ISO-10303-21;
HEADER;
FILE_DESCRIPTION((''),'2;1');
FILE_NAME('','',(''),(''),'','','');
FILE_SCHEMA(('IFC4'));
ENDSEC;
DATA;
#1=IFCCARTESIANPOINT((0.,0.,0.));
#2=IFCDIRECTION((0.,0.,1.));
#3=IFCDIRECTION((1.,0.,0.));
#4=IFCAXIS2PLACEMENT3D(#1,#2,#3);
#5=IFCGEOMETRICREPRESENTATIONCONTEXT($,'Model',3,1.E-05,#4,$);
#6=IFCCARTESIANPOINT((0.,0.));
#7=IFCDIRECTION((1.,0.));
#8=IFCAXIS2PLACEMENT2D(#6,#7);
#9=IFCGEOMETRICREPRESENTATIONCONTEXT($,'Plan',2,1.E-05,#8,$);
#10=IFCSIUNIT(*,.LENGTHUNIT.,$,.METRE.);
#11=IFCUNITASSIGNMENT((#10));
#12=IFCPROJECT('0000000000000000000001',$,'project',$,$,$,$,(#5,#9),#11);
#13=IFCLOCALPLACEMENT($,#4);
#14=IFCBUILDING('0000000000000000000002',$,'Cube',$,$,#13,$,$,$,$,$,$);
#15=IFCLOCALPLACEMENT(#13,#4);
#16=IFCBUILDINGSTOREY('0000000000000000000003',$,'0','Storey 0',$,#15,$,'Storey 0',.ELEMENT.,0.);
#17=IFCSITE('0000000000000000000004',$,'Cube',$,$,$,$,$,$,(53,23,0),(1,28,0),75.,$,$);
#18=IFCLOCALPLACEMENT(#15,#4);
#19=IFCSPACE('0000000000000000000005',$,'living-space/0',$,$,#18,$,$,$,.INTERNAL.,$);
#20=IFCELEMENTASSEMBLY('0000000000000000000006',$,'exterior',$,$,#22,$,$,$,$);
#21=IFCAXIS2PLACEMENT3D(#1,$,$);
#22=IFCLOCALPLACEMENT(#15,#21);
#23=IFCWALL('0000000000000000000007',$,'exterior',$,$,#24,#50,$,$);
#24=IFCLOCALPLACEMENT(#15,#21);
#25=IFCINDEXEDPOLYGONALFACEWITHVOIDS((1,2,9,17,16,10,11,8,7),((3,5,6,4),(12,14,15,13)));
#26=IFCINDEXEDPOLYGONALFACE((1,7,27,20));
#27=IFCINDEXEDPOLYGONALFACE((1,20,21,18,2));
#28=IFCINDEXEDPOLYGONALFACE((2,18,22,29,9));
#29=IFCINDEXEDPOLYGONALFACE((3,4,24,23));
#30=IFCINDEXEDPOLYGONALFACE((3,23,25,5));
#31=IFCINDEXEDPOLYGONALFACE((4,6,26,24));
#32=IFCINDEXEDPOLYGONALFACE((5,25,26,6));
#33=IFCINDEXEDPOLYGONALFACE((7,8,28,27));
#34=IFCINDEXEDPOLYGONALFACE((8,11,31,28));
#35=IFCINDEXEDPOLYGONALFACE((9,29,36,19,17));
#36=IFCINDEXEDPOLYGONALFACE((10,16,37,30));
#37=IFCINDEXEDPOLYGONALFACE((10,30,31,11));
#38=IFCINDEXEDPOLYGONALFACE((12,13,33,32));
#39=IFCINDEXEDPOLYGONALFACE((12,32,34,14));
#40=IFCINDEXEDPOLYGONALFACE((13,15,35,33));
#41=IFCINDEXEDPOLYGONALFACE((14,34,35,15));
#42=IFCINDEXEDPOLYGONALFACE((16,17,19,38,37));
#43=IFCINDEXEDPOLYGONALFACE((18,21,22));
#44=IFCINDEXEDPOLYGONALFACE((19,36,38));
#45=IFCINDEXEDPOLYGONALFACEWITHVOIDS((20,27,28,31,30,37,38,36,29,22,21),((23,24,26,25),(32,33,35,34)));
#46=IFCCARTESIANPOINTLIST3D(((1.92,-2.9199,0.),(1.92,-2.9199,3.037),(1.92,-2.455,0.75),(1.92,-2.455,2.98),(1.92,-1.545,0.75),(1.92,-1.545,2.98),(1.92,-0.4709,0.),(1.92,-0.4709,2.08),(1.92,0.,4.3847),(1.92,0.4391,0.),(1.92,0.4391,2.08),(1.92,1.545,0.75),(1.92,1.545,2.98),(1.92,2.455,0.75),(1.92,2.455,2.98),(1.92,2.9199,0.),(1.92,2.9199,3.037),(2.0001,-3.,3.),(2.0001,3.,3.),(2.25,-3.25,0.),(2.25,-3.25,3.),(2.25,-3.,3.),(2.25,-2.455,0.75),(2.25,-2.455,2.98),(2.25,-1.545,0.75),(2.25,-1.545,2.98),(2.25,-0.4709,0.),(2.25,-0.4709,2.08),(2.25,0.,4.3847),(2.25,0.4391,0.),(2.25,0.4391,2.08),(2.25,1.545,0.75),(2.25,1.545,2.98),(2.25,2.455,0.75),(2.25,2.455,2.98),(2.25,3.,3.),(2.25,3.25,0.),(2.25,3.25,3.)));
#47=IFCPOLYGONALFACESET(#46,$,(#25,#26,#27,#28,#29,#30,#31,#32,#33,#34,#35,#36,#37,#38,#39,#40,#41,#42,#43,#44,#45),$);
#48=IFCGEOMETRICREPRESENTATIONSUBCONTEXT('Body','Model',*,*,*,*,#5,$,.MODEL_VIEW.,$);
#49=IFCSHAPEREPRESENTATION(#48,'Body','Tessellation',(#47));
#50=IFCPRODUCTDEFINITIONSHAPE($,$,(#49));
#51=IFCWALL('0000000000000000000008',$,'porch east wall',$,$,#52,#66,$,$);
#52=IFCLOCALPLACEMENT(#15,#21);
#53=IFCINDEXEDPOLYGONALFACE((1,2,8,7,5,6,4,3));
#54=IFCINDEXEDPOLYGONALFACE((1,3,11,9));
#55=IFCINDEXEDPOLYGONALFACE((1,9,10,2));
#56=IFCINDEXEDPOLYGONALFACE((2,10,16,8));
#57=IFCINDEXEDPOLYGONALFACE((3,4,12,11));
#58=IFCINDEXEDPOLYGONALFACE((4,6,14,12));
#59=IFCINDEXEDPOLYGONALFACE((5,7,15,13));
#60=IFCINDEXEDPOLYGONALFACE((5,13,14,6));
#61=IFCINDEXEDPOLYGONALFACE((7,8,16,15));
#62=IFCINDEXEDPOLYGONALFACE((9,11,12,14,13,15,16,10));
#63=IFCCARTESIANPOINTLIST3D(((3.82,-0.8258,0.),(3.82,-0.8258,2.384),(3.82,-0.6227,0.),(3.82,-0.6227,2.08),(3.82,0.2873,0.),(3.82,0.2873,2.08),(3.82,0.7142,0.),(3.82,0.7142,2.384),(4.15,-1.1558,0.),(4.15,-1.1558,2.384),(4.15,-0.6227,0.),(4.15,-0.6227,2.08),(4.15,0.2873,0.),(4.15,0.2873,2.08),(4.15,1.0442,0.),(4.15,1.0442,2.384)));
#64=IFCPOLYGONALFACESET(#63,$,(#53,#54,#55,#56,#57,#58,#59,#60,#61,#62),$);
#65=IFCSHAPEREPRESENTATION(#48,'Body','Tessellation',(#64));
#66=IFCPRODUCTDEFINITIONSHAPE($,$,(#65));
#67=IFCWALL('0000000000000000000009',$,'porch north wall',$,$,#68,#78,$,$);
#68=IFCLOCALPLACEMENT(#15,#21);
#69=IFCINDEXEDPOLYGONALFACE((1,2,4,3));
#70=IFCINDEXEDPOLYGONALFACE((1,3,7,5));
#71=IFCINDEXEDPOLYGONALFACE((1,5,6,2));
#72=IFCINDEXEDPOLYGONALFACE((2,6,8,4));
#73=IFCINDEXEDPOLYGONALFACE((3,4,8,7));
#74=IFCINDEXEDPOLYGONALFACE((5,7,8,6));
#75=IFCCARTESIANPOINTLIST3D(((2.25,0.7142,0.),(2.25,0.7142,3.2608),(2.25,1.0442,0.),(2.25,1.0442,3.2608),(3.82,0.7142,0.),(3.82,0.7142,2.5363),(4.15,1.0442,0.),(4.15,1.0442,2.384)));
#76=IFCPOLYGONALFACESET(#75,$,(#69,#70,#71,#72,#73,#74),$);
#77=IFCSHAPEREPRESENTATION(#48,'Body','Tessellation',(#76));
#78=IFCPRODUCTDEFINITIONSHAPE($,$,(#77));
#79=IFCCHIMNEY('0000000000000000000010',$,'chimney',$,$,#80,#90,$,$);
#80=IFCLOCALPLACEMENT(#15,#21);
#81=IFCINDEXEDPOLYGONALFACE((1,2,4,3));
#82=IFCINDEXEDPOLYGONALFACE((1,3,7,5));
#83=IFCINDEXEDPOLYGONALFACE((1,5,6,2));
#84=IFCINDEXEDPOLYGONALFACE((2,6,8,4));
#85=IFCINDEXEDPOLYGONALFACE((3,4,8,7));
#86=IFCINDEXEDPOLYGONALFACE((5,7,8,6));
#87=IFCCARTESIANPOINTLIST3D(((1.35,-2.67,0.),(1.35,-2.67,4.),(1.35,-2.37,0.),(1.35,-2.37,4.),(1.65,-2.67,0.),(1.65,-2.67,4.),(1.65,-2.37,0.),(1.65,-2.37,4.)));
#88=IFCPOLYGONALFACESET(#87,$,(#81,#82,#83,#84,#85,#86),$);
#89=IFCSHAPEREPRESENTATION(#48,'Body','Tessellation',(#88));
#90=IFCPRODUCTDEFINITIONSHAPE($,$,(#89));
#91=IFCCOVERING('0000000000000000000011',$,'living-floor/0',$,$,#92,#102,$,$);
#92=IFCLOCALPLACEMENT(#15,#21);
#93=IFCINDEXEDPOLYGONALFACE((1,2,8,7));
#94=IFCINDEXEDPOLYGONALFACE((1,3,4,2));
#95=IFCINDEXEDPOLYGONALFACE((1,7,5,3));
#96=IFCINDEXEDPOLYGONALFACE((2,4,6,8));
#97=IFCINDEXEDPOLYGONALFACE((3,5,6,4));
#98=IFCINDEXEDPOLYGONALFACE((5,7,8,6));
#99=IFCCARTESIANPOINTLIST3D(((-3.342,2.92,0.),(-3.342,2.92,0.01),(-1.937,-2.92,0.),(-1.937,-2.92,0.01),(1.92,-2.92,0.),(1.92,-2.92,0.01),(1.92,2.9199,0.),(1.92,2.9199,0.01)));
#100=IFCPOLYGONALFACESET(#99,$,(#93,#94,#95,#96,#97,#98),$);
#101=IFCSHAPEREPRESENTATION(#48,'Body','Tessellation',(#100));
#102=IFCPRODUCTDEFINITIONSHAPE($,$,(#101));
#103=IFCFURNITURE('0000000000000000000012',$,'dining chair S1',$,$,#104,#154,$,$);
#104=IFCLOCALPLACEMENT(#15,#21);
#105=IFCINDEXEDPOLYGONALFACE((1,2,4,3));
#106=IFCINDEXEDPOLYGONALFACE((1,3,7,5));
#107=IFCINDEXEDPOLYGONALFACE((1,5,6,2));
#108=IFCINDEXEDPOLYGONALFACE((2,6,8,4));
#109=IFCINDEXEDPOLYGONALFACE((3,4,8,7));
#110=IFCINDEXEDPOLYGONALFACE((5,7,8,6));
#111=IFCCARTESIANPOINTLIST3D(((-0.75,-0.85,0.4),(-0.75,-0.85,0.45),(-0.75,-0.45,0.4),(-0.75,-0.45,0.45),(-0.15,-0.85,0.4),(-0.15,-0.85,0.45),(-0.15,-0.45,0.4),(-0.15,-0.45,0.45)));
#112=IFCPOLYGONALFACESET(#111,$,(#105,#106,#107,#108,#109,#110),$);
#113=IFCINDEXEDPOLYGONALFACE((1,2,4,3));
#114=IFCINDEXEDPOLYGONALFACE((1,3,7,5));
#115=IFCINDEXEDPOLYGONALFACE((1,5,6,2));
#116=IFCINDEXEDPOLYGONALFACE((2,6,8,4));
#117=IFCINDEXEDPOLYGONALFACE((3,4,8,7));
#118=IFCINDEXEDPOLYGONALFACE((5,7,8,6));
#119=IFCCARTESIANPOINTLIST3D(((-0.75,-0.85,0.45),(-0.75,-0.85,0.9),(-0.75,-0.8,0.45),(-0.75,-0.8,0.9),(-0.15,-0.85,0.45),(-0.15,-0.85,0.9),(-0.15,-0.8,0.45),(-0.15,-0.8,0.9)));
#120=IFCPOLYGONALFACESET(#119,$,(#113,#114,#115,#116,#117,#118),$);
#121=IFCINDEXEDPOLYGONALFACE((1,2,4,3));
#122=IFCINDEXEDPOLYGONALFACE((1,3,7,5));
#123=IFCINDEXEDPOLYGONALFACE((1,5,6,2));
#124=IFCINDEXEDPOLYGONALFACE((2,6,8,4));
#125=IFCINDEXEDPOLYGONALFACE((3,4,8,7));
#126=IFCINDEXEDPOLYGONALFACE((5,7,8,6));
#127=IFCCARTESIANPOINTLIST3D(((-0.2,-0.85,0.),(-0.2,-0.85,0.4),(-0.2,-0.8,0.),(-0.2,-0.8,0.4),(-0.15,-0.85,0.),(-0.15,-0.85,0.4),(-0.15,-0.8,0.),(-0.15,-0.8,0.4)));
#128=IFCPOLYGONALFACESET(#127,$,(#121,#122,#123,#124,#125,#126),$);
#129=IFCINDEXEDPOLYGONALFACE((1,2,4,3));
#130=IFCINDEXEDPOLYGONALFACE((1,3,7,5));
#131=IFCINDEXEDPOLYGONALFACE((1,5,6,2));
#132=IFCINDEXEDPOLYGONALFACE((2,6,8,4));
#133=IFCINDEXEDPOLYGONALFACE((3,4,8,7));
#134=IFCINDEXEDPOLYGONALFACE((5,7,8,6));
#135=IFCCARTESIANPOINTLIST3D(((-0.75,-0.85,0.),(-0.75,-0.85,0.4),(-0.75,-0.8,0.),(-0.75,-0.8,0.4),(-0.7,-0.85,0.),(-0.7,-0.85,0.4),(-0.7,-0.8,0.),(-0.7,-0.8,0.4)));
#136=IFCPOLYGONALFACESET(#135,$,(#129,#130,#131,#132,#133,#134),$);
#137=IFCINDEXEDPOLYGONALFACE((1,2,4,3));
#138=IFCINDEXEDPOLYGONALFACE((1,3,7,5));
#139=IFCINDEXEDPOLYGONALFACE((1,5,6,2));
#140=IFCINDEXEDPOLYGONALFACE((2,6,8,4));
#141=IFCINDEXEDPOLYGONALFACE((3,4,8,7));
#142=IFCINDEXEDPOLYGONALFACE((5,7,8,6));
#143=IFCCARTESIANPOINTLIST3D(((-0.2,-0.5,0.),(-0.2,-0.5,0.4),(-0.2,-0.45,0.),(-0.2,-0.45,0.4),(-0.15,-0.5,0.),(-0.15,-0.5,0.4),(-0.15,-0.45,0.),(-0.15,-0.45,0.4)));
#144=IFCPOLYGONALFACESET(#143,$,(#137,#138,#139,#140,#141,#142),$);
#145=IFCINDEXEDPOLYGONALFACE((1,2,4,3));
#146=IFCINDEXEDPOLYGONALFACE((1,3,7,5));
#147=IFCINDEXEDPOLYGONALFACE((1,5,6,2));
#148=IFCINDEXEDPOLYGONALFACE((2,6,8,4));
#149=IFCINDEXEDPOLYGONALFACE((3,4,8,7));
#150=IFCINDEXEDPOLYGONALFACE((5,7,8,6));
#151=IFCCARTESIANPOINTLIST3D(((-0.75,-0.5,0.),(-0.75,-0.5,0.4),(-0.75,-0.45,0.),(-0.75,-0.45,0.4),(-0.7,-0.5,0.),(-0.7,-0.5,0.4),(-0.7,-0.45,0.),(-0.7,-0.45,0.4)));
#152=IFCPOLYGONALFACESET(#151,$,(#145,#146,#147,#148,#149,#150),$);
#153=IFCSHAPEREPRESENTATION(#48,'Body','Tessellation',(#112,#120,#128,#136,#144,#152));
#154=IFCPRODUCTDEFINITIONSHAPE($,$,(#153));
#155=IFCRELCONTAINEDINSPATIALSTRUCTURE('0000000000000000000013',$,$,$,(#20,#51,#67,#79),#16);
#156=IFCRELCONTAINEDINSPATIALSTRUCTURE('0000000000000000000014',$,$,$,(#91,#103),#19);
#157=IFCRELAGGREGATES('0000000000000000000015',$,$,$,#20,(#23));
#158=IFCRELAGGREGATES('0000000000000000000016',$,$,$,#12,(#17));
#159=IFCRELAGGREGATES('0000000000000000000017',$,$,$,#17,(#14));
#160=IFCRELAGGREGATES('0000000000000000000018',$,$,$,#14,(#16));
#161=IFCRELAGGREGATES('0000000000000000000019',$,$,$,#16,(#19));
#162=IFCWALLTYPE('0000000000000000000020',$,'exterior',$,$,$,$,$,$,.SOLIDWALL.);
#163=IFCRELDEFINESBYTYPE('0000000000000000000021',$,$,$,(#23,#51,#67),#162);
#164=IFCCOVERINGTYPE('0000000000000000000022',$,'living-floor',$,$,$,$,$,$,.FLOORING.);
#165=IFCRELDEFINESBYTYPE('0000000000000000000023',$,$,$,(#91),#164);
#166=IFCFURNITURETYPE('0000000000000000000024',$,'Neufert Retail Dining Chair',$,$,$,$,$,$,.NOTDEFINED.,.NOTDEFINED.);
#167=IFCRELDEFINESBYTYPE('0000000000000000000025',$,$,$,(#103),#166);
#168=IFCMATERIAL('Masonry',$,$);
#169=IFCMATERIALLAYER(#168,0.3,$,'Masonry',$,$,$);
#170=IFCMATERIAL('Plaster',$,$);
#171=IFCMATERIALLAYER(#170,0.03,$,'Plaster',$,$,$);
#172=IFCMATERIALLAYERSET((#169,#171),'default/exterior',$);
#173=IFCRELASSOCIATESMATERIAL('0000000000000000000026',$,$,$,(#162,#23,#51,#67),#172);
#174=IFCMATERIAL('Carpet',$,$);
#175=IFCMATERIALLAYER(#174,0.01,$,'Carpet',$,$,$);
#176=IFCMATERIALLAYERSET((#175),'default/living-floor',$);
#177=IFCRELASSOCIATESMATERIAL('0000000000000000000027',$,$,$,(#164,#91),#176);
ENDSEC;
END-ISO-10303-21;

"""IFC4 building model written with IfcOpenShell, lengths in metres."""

from ifc_helpers import new_model, entity, si_unit, frame, origin, origin_with_axes, origin_2d_with_axis, place, context, subcontext, project, spatial, polyline, line, indexed_curve, outline, extrude, clip, halfspace, bounded_halfspace, shape, source, transform, mapped, material, layer, layer_set, layer_usage, type_object, type_shapes, element, aggregate, save


model = new_model("IFC4")

# Units and contexts
model_context = context("Model", 3, precision=1e-05, world=origin_with_axes())
plan_context = context("Plan", 2, precision=1e-05, world=origin_2d_with_axis())
body_context_1 = subcontext(model_context, "Body", "Model", "MODEL_VIEW")
body_context_2 = subcontext(plan_context, "Body", "Plan", "PLAN_VIEW")
ifc_project = project(units=[si_unit("LENGTHUNIT", "METRE")], contexts=[model_context, plan_context])

# Site, building, storey
site = spatial("IfcSite", under=ifc_project, Name="Cube", RefLatitude=(53, 23, 0), RefLongitude=(1, 28, 0), RefElevation=75.0)
building_placement = place(None, origin_with_axes())
building = spatial("IfcBuilding", under=site, at=building_placement, Name="Cube")
storey_placement = place(building_placement, origin_with_axes())
storey = spatial("IfcBuildingStorey", under=building, at=storey_placement, Name="0", Description="Storey 0", LongName="Storey 0", CompositionType="ELEMENT", Elevation=0.0)

# Element assembly, wall, openings
ifc_material_1 = material(Name="Masonry")
ifc_layer_1 = layer(ifc_material_1, 0.3, Name="Masonry")
ifc_material_2 = material(Name="Plaster")
ifc_layer_2 = layer(ifc_material_2, 0.03, Name="Plaster")
ifc_layer_set_1 = layer_set([ifc_layer_1, ifc_layer_2], Name="default/exterior")
wall_type = type_object("IfcWallType", Name="exterior", PredefinedType="SOLIDWALL", material=ifc_layer_set_1)
assembly_1_placement = place(storey_placement, frame((2.0, -3.0, 0.0), z_axis=(0.0, 0.0, 1.0), x_axis=(0.0, 1.0, 0.0)))
assembly_1 = element("IfcElementAssembly", 1, at=assembly_1_placement, inside=storey, Name="exterior")
ifc_layer_usage_1 = layer_usage(ifc_layer_set_1, "AXIS2", "POSITIVE", -0.25)
wall_1_placement = place(assembly_1_placement, origin_with_axes())
wall_1 = element("IfcWall", 2, at=wall_1_placement, type_object=wall_type, material=ifc_layer_usage_1, Name="exterior", context=body_context_1, shape_type="Clipping", body=[
    clip(clip(clip(clip(extrude(outline(polyline([(0.0801, 0.08), (-0.25, -0.25), (6.25, -0.25), (5.9199, 0.08), (0.0801, 0.08)])), origin(), (0.0, 0.0, 1.0), 4.385), bounded_halfspace(frame((6.0, 0.0, 3.0), z_axis=(0.419069, 0.0, 0.907954), x_axis=(0.0, -1.0, 0.0)), False, origin(), polyline([(6.0, -1.0), (3.0, -1.0), (3.0, 1.0), (6.0, 1.0), (6.0, -1.0)]))), bounded_halfspace(frame((6.0, 0.0, 3.0), z_axis=(0.0, 0.0, 1.0), x_axis=(0.0, 1.0, 0.0)), False, origin(), polyline([(6.0, 1.0), (7.0, 1.0), (7.0, -1.0), (6.0, -1.0), (6.0, 1.0)]))), bounded_halfspace(frame((3.0, 0.0, 4.3847), z_axis=(-0.419069, 0.0, 0.907954), x_axis=(0.0, -1.0, 0.0)), False, origin(), polyline([(3.0, -1.0), (0.0, -1.0), (0.0, 1.0), (3.0, 1.0), (3.0, -1.0)]))), bounded_halfspace(frame((0.0, 0.0, 3.0), z_axis=(0.0, 0.0, 1.0), x_axis=(0.0, -1.0, 0.0)), False, origin(), polyline([(0.0, -1.0), (-1.0, -1.0), (-1.0, 1.0), (0.0, 1.0), (0.0, -1.0)]))),
])
opening_1_placement = place(wall_1_placement, frame((0.545, -0.25, 0.75), z_axis=(0.0, 0.0, 1.0), x_axis=(1.0, 0.0, 0.0)))
element("IfcOpeningElement", 3, at=opening_1_placement, cuts=wall_1, PredefinedType="OPENING", context=body_context_1, shape_type="SweptSolid", body=[
    extrude(outline(polyline([(0.0, -0.02), (0.91, -0.02), (0.91, 0.35), (0.0, 0.35), (0.0, -0.02)])), origin(), (0.0, 0.0, 1.0), 2.23),
])
opening_2_placement = place(wall_1_placement, frame((4.545, -0.25, 0.75), z_axis=(0.0, 0.0, 1.0), x_axis=(1.0, 0.0, 0.0)))
element("IfcOpeningElement", 4, at=opening_2_placement, cuts=wall_1, PredefinedType="OPENING", context=body_context_1, shape_type="SweptSolid", body=[
    extrude(outline(polyline([(0.0, -0.02), (0.91, -0.02), (0.91, 0.35), (0.0, 0.35), (0.0, -0.02)])), origin(), (0.0, 0.0, 1.0), 2.23),
])
shared_shape_1 = source(origin_with_axes(), body_context_1, "Body", "SweptSolid", [
    extrude(outline(indexed_curve([(0.0, 0.0), (0.91, 0.0), (0.91, 2.08), (0.0, 2.08)], segments=[line(1, 2, 3, 4, 1)])), frame((0.0, -0.6, 0.0), z_axis=(0.0, -1.0, 0.0), x_axis=(1.0, 0.0, 0.0)), (0.0, 0.0, -1.0), 1.2),
])
opening_3_placement = place(wall_1_placement, frame((2.5291, -0.25, 0.0), z_axis=(0.0, 0.0, 1.0), x_axis=(1.0, 0.0, 0.0)))
element("IfcOpeningElement", 5, at=opening_3_placement, cuts=wall_1, PredefinedType="OPENING", context=body_context_1, shape_type="MappedRepresentation", body=[
    mapped(shared_shape_1, transform((0.0, 0.0, 0.0), x_axis=(1.0, 0.0, 0.0), y_axis=(0.0, 1.0, 0.0), z_axis=(0.0, 0.0, 1.0), scale=1.0)),
])
aggregate(assembly_1, [wall_1])

# Wall, opening
ifc_layer_usage_2 = layer_usage(ifc_layer_set_1, "AXIS2", "POSITIVE", 0.0)
wall_2_placement = place(storey_placement, frame((4.15, -1.1558, 0.0), z_axis=(0.0, 0.0, 1.0), x_axis=(0.0, 1.0, 0.0)))
wall_2 = element("IfcWall", 6, at=wall_2_placement, inside=storey, type_object=wall_type, material=ifc_layer_usage_2, Name="porch east wall", context=body_context_1, shape_type="SweptSolid", body=[
    extrude(outline(indexed_curve([(0.0, 0.0), (0.33, 0.33), (1.87, 0.33), (2.2, 0.0)], segments=[line(1, 2, 3, 4, 1)])), origin_with_axes(), (0.0, 0.0, 1.0), 2.384),
])
shared_shape_2 = source(origin_with_axes(), body_context_1, "Body", "SweptSolid", [
    extrude(outline(indexed_curve([(0.0, 0.0), (0.91, 0.0), (0.91, 2.08), (0.0, 2.08)], segments=[line(1, 2, 3, 4, 1)])), frame((0.0, -0.6, 0.0), z_axis=(0.0, -1.0, 0.0), x_axis=(1.0, 0.0, 0.0)), (0.0, 0.0, -1.0), 1.2),
])
opening_4_placement = place(wall_2_placement, frame((0.5331, 0.0, 0.0), z_axis=(0.0, 0.0, 1.0), x_axis=(1.0, 0.0, 0.0)))
element("IfcOpeningElement", 7, at=opening_4_placement, cuts=wall_2, PredefinedType="OPENING", context=body_context_1, shape_type="MappedRepresentation", body=[
    mapped(shared_shape_2, transform((0.0, 0.0, 0.0), x_axis=(1.0, 0.0, 0.0), y_axis=(0.0, 1.0, 0.0), z_axis=(0.0, 0.0, 1.0), scale=1.0)),
])

# Wall
ifc_layer_usage_3 = layer_usage(ifc_layer_set_1, "AXIS2", "POSITIVE", 0.0)
wall_3_placement = place(storey_placement, frame((4.15, 1.0442, 0.0), z_axis=(0.0, 0.0, 1.0), x_axis=(-1.0, 0.0, 0.0)))
element("IfcWall", 8, at=wall_3_placement, inside=storey, type_object=wall_type, material=ifc_layer_usage_3, Name="porch north wall", context=body_context_1, shape_type="Clipping", body=[
    clip(extrude(outline(indexed_curve([(0.0, 0.0), (1.9, 0.0), (1.9, 0.33), (0.33, 0.33)], segments=[line(1, 2, 3, 4, 1)])), origin_with_axes(), (0.0, 0.0, 1.0), 3.5), halfspace(frame((0.0, 0.0, 2.384), z_axis=(-0.419, 0.0, 0.908), x_axis=(0.0, 1.0, 0.0)), False)),
])

# Chimney
chimney_placement = place(storey_placement, frame((1.35, -2.67, 0.0), z_axis=(0.0, 0.0, 1.0), x_axis=(1.0, 0.0, 0.0)))
element("IfcChimney", 9, at=chimney_placement, inside=storey, Name="chimney", context=body_context_1, shape_type="SweptSolid", body=[
    extrude(outline(indexed_curve([(0.0, 0.0), (0.3, 0.0), (0.3, 0.3), (0.0, 0.3)])), None, (0.0, 0.0, 1.0), 4.0),
])

# Shared definitions
space_placement = place(storey_placement, origin_with_axes())
space = spatial("IfcSpace", under=storey, at=space_placement, Name="living-space/0", PredefinedType="INTERNAL")

# Covering
ifc_material_3 = material(Name="Carpet")
ifc_layer_3 = layer(ifc_material_3, 0.01, Name="Carpet")
ifc_layer_set_2 = layer_set([ifc_layer_3], Name="default/living-floor")
ifc_layer_usage_4 = layer_usage(ifc_layer_set_2, "AXIS3", "POSITIVE", 0.0)
covering_type = type_object("IfcCoveringType", Name="living-floor", PredefinedType="FLOORING", material=ifc_layer_set_2)
covering_placement = place(space_placement, origin_with_axes())
element("IfcCovering", 10, at=covering_placement, inside=space, type_object=covering_type, material=ifc_layer_usage_4, Name="living-floor/0", context=body_context_1, shape_type="SweptSolid", body=[
    extrude(outline(polyline([(1.92, 2.9199), (-3.342, 2.92), (-1.937, -2.92), (1.92, -2.92), (1.92, 2.9199)])), origin_with_axes(), (0.0, 0.0, 1.0), 0.01),
])

# Furniture
furniture_type_1 = type_object("IfcFurnitureType", Name="Neufert Retail Dining Chair", AssemblyPlace="NOTDEFINED", PredefinedType="NOTDEFINED")
shared_shape_3 = source(origin_with_axes(), body_context_1, "Body", "SweptSolid", [
    extrude(outline(indexed_curve([(-0.3, 0.0), (0.3, 0.0), (0.3, -0.4), (-0.3, -0.4)], segments=[line(1, 2, 3, 4, 1)])), frame((0.0, 0.0, 0.45), z_axis=(0.0, 0.0, 1.0), x_axis=(1.0, 0.0, 0.0)), (0.0, 0.0, -1.0), 0.05),
    extrude(outline(indexed_curve([(-0.3, 0.0), (0.3, 0.0), (0.3, -0.05), (-0.3, -0.05)], segments=[line(1, 2, 3, 4, 1)])), frame((0.0, 0.0, 0.9), z_axis=(0.0, 0.0, 1.0), x_axis=(1.0, 0.0, 0.0)), (0.0, 0.0, -1.0), 0.45),
    extrude(outline(indexed_curve([(-0.3, 0.0), (-0.25, 0.0), (-0.25, -0.05), (-0.3, -0.05)], segments=[line(1, 2, 3, 4, 1)])), origin_with_axes(), (0.0, 0.0, 1.0), 0.4),
    extrude(outline(indexed_curve([(0.3, 0.0), (0.25, 0.0), (0.25, -0.05), (0.3, -0.05)], segments=[line(1, 2, 3, 4, 1)])), origin_with_axes(), (0.0, 0.0, 1.0), 0.4),
    extrude(outline(indexed_curve([(-0.3, -0.4), (-0.25, -0.4), (-0.25, -0.35), (-0.3, -0.35)], segments=[line(1, 2, 3, 4, 1)])), origin_with_axes(), (0.0, 0.0, 1.0), 0.4),
    extrude(outline(indexed_curve([(0.3, -0.4), (0.25, -0.4), (0.25, -0.35), (0.3, -0.35)], segments=[line(1, 2, 3, 4, 1)])), origin_with_axes(), (0.0, 0.0, 1.0), 0.4),
])
shared_shape_4 = source(origin_with_axes(), body_context_2, "Body", "Curve2D", [
    entity("IfcIndexedPolyCurve", entity("IfcCartesianPointList2D", [[-0.3, -0.4], [0.3, -0.4]])),
    entity("IfcIndexedPolyCurve", entity("IfcCartesianPointList2D", [[-0.3, -0.4], [-0.3, -0.3], [-0.2121, -0.0879], [0.0, 0.0], [0.2121, -0.0879], [0.3, -0.3], [0.3, -0.4]]), [entity("IfcLineIndex", [1, 2]), entity("IfcArcIndex", [2, 3, 4]), entity("IfcArcIndex", [4, 5, 6]), entity("IfcLineIndex", [6, 7])]),
    entity("IfcIndexedPolyCurve", entity("IfcCartesianPointList2D", [[-0.26, -0.4], [-0.26, -0.3], [-0.1838, -0.1162], [0.0, -0.04], [0.1838, -0.1162], [0.26, -0.3], [0.26, -0.4]]), [entity("IfcLineIndex", [1, 2]), entity("IfcArcIndex", [2, 3, 4]), entity("IfcArcIndex", [4, 5, 6]), entity("IfcLineIndex", [6, 7])]),
])
type_shapes(furniture_type_1, [shared_shape_3, shared_shape_4])
for number, where, z_axis, x_axis, name in (
    (11, (-0.45, -0.85, 0.0), (0.0, 0.0, 1.0), (-1.0, 0.0, 0.0), "dining chair S1"),
):
    element("IfcFurniture", number, at=place(space_placement, frame(where, z_axis=z_axis, x_axis=x_axis)), inside=space, type_object=furniture_type_1, Name=name, shapes=[
        shape(body_context_1, "Body", "MappedRepresentation", [mapped(shared_shape_3, transform((0.0, 0.0, 0.0), x_axis=(1.0, 0.0, 0.0), y_axis=(0.0, 1.0, 0.0), z_axis=(0.0, 0.0, 1.0), scale=1.0))]),
        shape(body_context_2, "Body", "MappedRepresentation", [mapped(shared_shape_4, transform((0.0, 0.0, 0.0), x_axis=(1.0, 0.0, 0.0), y_axis=(0.0, 1.0, 0.0), z_axis=(0.0, 0.0, 1.0), scale=1.0))]),
    ])

save(model, "model.ifc")
